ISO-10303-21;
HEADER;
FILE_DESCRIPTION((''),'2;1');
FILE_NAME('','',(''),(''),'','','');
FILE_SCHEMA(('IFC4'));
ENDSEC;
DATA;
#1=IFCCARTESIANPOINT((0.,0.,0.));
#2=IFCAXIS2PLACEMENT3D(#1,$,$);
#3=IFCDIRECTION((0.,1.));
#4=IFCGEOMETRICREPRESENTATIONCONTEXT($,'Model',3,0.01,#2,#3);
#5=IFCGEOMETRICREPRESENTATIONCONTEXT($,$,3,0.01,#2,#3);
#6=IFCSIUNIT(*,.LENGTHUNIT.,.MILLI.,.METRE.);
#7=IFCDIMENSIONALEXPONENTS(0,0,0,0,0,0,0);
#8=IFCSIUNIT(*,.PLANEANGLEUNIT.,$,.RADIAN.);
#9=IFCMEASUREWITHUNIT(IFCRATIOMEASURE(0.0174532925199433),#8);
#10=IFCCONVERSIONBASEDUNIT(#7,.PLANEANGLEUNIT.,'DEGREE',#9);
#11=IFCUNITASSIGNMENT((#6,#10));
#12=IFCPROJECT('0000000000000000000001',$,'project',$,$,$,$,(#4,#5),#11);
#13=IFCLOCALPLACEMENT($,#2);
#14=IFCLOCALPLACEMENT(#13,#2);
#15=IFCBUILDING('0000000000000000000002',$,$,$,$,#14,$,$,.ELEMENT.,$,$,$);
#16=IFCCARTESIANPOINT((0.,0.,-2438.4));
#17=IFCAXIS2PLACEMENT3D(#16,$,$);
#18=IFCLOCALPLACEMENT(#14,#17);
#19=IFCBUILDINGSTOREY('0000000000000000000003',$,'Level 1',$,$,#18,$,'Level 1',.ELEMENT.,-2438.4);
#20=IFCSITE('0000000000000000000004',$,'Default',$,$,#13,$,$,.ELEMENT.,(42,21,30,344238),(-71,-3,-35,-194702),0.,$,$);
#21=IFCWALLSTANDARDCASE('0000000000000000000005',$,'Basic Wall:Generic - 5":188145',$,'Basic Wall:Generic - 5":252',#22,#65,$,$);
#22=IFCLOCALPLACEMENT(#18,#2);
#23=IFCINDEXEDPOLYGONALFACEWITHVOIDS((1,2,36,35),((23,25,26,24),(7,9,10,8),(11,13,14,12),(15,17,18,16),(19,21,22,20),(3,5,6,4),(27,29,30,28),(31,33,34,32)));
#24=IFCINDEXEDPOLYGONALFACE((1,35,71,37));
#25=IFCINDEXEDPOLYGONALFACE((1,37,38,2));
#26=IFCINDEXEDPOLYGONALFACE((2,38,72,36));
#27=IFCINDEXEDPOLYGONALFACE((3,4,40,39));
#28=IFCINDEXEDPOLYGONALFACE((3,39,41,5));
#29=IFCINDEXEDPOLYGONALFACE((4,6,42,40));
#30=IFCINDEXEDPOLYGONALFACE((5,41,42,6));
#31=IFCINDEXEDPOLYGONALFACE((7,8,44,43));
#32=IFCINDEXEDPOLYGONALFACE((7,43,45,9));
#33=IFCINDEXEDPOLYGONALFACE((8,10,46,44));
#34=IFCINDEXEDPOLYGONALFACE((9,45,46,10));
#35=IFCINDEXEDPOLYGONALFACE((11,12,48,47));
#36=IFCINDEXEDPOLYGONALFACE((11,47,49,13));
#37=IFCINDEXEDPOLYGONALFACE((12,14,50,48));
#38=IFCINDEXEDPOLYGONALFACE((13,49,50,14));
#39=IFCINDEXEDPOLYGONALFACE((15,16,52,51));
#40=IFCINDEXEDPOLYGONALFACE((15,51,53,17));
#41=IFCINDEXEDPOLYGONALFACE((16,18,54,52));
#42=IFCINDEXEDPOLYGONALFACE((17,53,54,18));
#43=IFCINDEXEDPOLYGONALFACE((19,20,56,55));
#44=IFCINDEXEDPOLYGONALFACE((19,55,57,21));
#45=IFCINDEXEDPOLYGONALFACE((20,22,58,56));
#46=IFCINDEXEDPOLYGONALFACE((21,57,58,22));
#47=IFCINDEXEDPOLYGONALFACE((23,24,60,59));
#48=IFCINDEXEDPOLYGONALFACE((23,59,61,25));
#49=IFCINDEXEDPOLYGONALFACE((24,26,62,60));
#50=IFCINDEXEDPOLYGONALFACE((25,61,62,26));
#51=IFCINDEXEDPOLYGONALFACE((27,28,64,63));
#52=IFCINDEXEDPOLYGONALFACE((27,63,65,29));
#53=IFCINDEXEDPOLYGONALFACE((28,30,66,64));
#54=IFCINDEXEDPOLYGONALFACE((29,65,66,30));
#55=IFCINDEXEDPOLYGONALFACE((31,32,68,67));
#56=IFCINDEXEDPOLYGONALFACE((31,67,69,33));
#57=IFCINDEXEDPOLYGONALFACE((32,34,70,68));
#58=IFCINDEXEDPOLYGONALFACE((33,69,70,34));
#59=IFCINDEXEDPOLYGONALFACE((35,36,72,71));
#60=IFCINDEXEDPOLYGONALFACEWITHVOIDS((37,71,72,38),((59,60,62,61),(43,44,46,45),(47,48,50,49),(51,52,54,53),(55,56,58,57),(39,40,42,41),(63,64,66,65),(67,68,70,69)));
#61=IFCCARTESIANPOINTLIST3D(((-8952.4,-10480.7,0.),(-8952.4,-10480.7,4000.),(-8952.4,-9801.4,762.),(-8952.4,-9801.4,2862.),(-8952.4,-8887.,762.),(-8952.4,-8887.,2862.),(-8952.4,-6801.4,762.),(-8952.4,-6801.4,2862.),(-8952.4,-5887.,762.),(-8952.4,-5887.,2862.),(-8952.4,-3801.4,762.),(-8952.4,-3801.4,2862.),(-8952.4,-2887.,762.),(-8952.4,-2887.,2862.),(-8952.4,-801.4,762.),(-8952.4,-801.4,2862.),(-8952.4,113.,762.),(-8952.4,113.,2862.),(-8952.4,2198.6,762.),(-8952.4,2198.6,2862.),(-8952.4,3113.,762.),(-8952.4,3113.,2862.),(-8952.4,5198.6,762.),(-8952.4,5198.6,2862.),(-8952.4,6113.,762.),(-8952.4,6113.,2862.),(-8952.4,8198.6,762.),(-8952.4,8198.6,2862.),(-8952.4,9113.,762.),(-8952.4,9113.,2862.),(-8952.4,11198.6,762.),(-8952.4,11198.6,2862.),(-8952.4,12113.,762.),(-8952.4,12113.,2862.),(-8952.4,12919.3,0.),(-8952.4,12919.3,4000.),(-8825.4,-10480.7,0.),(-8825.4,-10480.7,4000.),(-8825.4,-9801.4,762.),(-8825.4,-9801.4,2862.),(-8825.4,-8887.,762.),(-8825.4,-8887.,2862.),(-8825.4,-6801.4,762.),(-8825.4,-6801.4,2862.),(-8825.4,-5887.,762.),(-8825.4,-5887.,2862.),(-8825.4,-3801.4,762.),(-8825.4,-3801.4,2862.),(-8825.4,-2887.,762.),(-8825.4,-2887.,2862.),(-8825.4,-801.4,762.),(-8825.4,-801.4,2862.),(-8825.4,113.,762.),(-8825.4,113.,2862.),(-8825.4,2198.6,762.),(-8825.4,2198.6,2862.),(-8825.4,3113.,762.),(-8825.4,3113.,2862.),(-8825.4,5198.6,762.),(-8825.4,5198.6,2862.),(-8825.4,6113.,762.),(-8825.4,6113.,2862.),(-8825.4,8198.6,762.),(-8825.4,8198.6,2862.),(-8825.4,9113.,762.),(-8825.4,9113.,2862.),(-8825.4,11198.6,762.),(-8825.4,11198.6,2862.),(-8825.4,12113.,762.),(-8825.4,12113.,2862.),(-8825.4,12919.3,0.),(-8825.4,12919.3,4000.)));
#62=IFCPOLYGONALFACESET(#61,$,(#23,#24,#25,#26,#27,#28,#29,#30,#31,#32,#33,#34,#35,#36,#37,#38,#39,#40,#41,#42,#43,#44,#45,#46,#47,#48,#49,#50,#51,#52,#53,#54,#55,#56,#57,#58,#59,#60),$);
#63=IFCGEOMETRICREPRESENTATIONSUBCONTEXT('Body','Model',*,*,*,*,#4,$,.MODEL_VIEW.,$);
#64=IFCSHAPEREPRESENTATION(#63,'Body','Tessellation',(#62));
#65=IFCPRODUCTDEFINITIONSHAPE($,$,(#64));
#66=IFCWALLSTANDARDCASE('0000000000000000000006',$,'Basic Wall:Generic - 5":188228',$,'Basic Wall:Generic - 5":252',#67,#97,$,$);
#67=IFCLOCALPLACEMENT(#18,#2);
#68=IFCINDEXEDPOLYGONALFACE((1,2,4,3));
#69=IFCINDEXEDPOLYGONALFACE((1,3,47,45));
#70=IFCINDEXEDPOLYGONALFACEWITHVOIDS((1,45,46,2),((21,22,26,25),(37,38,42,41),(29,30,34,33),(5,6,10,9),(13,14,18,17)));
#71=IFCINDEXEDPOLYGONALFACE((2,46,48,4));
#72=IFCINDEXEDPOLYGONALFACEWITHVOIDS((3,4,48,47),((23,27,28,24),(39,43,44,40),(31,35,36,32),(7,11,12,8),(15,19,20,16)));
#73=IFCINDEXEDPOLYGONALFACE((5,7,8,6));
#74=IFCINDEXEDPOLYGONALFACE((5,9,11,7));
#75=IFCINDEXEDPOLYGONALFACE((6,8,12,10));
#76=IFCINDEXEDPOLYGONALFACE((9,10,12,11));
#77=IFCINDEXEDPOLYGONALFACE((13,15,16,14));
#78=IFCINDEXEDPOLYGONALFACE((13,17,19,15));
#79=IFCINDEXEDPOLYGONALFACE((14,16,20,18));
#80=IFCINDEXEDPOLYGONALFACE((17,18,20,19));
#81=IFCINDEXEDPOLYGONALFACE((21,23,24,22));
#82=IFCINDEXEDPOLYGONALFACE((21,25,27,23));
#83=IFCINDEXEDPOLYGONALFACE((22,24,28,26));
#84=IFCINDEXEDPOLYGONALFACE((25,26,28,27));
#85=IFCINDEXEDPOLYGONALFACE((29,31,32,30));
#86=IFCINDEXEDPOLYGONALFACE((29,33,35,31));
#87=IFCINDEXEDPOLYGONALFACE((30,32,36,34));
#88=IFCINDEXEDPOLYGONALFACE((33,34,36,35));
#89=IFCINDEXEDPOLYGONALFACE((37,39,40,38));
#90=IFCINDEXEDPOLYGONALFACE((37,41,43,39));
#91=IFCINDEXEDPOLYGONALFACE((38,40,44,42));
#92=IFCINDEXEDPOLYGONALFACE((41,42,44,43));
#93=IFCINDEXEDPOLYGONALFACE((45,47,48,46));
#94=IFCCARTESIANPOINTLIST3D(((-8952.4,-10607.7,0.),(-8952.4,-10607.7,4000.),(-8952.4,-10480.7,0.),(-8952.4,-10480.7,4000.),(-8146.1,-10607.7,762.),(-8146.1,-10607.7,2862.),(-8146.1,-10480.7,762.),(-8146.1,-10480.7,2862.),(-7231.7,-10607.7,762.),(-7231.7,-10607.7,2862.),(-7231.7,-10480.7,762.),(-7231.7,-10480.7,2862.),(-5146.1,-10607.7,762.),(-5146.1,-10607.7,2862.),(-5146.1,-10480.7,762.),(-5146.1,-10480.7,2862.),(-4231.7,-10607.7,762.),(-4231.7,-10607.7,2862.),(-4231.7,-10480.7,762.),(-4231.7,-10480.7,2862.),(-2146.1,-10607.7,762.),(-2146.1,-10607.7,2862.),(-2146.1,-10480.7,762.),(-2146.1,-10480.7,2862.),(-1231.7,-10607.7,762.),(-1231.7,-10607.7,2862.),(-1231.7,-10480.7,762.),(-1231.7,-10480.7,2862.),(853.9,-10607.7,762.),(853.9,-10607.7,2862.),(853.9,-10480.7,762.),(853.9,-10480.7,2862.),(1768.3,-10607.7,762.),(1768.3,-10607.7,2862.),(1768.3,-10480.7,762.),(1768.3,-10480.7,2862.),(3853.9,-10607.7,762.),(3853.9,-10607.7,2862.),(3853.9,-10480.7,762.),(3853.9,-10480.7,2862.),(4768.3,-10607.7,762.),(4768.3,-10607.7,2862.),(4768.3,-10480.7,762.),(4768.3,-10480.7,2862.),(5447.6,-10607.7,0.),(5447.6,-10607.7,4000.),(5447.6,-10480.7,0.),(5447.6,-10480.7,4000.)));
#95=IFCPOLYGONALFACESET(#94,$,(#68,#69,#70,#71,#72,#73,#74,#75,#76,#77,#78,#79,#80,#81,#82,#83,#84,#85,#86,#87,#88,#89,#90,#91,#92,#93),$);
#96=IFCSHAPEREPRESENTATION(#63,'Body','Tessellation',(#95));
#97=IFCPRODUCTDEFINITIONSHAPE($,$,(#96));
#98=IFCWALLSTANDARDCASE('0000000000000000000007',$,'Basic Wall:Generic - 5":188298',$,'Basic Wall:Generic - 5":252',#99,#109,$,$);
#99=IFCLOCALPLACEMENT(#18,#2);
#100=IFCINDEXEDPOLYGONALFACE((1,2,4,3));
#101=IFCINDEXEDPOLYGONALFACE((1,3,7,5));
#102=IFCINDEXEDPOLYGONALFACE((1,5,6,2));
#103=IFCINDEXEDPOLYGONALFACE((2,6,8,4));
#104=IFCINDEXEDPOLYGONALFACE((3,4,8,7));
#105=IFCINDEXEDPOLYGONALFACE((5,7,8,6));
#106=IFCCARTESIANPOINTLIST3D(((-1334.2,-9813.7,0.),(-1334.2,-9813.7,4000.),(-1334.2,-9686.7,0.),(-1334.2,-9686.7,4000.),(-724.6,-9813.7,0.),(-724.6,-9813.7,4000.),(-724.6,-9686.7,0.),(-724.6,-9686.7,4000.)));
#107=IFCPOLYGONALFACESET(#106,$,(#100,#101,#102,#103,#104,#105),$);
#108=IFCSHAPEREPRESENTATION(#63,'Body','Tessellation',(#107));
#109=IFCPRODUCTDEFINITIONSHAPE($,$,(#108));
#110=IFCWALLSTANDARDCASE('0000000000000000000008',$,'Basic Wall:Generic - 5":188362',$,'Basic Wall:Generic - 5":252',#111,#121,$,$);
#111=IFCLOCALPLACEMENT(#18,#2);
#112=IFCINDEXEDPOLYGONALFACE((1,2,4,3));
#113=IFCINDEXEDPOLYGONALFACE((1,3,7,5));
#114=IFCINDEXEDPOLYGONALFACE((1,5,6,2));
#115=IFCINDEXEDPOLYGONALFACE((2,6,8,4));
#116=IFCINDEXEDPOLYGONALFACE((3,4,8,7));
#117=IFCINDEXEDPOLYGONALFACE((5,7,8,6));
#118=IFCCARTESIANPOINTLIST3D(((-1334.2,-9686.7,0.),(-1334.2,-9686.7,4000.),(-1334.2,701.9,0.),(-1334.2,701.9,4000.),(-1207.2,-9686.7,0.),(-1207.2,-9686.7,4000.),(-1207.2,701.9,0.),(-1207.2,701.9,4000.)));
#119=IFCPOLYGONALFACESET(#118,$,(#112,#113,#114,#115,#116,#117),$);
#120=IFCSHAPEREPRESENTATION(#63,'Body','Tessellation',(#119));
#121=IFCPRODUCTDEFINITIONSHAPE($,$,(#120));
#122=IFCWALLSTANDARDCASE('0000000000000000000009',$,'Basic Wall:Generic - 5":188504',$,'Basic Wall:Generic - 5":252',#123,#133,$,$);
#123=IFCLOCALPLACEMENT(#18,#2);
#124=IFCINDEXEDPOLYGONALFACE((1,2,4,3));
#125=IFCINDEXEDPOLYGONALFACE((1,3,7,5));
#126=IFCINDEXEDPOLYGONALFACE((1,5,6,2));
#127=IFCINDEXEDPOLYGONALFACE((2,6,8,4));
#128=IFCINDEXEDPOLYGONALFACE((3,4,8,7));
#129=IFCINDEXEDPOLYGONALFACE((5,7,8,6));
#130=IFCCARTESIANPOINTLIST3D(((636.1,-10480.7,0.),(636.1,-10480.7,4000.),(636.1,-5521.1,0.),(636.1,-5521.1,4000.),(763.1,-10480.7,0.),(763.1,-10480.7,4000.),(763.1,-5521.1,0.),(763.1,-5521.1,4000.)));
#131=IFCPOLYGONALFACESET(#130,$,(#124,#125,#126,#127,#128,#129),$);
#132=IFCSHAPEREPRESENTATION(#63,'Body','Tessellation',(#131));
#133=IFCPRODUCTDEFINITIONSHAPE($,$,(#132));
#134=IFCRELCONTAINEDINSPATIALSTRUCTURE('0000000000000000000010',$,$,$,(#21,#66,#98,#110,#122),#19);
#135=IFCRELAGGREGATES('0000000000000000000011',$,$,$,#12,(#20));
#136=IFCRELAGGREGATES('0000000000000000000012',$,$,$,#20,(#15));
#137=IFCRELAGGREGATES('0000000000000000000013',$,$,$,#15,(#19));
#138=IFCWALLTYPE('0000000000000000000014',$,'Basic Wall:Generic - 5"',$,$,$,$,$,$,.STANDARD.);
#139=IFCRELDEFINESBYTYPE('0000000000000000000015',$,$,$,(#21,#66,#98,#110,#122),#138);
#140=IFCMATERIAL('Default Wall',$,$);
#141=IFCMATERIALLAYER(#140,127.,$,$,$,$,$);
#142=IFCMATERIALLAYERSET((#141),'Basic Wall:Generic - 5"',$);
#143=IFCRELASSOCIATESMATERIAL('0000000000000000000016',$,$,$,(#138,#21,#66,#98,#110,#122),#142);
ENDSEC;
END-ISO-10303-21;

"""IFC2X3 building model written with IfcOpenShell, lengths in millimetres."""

from ifc_helpers import new_model, entity, si_unit, converted_unit, direction, frame, frame_2d, origin, place, context, subcontext, project, spatial, polyline, rectangle, extrude, clip, bounded_halfspace, material, layer, layer_set, layer_usage, type_object, element, save


model = new_model("IFC2X3")

# Units and contexts
model_context = context("Model", 3, precision=0.01, world=origin(), true_north=direction((0.0, 1.0)))
context_of_model = context(None, 3, precision=0.01, world=origin(), true_north=direction((0.0, 1.0)))
body_context = subcontext(model_context, "Body", "Model", "MODEL_VIEW")
ifc_project = project(units=[si_unit("LENGTHUNIT", "METRE", prefix="MILLI"), converted_unit("PLANEANGLEUNIT", "DEGREE", entity("IfcRatioMeasure", 0.0174532925199433), si_unit("PLANEANGLEUNIT", "RADIAN"), dimensions=[0, 0, 0, 0, 0, 0, 0])], contexts=[model_context, context_of_model])

# Site, building, storey
site_placement = place(None, origin())
site = spatial("IfcSite", under=ifc_project, at=site_placement, Name="Default", CompositionType="ELEMENT", RefLatitude=(42, 21, 30, 344238), RefLongitude=(-71, -3, -35, -194702), RefElevation=0.0)
building_placement = place(site_placement, origin())
building = spatial("IfcBuilding", under=site, at=building_placement, CompositionType="ELEMENT")
storey_placement = place(building_placement, frame((0.0, 0.0, -2438.4)))
storey = spatial("IfcBuildingStorey", under=building, at=storey_placement, Name="Level 1", LongName="Level 1", CompositionType="ELEMENT", Elevation=-2438.4)

# Walls, openings
ifc_material = material(Name="Default Wall")
ifc_layer = layer(ifc_material, 127.0)
ifc_layer_set = layer_set([ifc_layer], Name="Basic Wall:Generic - 5\"")
ifc_layer_usage_1 = layer_usage(ifc_layer_set, "AXIS2", "NEGATIVE", 63.5)
wall_type = type_object("IfcWallType", Name="Basic Wall:Generic - 5\"", PredefinedType="STANDARD", material=ifc_layer_set)
wall_1_placement = place(storey_placement, frame((-8888.9, -10480.7, 0.0), z_axis=(0.0, 0.0, 1.0), x_axis=(0.0, 1.0, 0.0)))
wall_1 = element("IfcWallStandardCase", 1, at=wall_1_placement, inside=storey, type_object=wall_type, material=ifc_layer_usage_1, Name="Basic Wall:Generic - 5\":188145", ObjectType="Basic Wall:Generic - 5\":252", context=body_context, shape_type="Clipping", body=[
    clip(extrude(rectangle(XDim=23400.0, YDim=127.0, at=frame_2d((11700.0, 0.0), x_axis=(-1.0, 0.0))), origin(), (0.0, 0.0, 1.0), 4000.0), bounded_halfspace(frame((0.0, -63.5, 4000.0), z_axis=(0.0, 0.0, -1.0), x_axis=(-1.0, 0.0, 0.0)), True, frame((0.0, -63.5, 4000.0)), polyline([(0.0, 0.0), (10928.6, 0.0), (11055.6, 0.0), (23273.0, 0.0), (23400.0, 0.0), (23400.0, 127.0), (0.0, 127.0), (0.0, 0.0)]))),
])
opening_1_placement = place(wall_1_placement, frame((21679.3, -63.5, 762.0)))
element("IfcOpeningElement", 2, at=opening_1_placement, cuts=wall_1, ObjectType="Opening", context=body_context, shape_type="SweptSolid", body=[
    extrude(rectangle(XDim=2100.0, YDim=914.4, at=frame_2d((1050.0, 457.2), x_axis=(-1.0, 0.0))), frame((0.0, 0.0, 0.0), z_axis=(0.0, 1.0, 0.0), x_axis=(0.0, 0.0, 1.0)), (0.0, 0.0, 1.0), 127.0),
])
opening_2_placement = place(wall_1_placement, frame((18679.3, -63.5, 762.0)))
element("IfcOpeningElement", 3, at=opening_2_placement, cuts=wall_1, ObjectType="Opening", context=body_context, shape_type="SweptSolid", body=[
    extrude(rectangle(XDim=2100.0, YDim=914.4, at=frame_2d((1050.0, 457.2), x_axis=(-1.0, 0.0))), frame((0.0, 0.0, 0.0), z_axis=(0.0, 1.0, 0.0), x_axis=(0.0, 0.0, 1.0)), (0.0, 0.0, 1.0), 127.0),
])
opening_3_placement = place(wall_1_placement, frame((15679.3, -63.5, 762.0)))
element("IfcOpeningElement", 4, at=opening_3_placement, cuts=wall_1, ObjectType="Opening", context=body_context, shape_type="SweptSolid", body=[
    extrude(rectangle(XDim=2100.0, YDim=914.4, at=frame_2d((1050.0, 457.2), x_axis=(-1.0, 0.0))), frame((0.0, 0.0, 0.0), z_axis=(0.0, 1.0, 0.0), x_axis=(0.0, 0.0, 1.0)), (0.0, 0.0, 1.0), 127.0),
])
opening_4_placement = place(wall_1_placement, frame((12679.3, -63.5, 762.0)))
element("IfcOpeningElement", 5, at=opening_4_placement, cuts=wall_1, ObjectType="Opening", context=body_context, shape_type="SweptSolid", body=[
    extrude(rectangle(XDim=2100.0, YDim=914.4, at=frame_2d((1050.0, 457.2), x_axis=(-1.0, 0.0))), frame((0.0, 0.0, 0.0), z_axis=(0.0, 1.0, 0.0), x_axis=(0.0, 0.0, 1.0)), (0.0, 0.0, 1.0), 127.0),
])
opening_5_placement = place(wall_1_placement, frame((9679.3, -63.5, 762.0)))
element("IfcOpeningElement", 6, at=opening_5_placement, cuts=wall_1, ObjectType="Opening", context=body_context, shape_type="SweptSolid", body=[
    extrude(rectangle(XDim=2100.0, YDim=914.4, at=frame_2d((1050.0, 457.2), x_axis=(-1.0, 0.0))), frame((0.0, 0.0, 0.0), z_axis=(0.0, 1.0, 0.0), x_axis=(0.0, 0.0, 1.0)), (0.0, 0.0, 1.0), 127.0),
])
opening_6_placement = place(wall_1_placement, frame((6679.3, -63.5, 762.0)))
element("IfcOpeningElement", 7, at=opening_6_placement, cuts=wall_1, ObjectType="Opening", context=body_context, shape_type="SweptSolid", body=[
    extrude(rectangle(XDim=2100.0, YDim=914.4, at=frame_2d((1050.0, 457.2), x_axis=(-1.0, 0.0))), frame((0.0, 0.0, 0.0), z_axis=(0.0, 1.0, 0.0), x_axis=(0.0, 0.0, 1.0)), (0.0, 0.0, 1.0), 127.0),
])
opening_7_placement = place(wall_1_placement, frame((3679.3, -63.5, 762.0)))
element("IfcOpeningElement", 8, at=opening_7_placement, cuts=wall_1, ObjectType="Opening", context=body_context, shape_type="SweptSolid", body=[
    extrude(rectangle(XDim=2100.0, YDim=914.4, at=frame_2d((1050.0, 457.2), x_axis=(-1.0, 0.0))), frame((0.0, 0.0, 0.0), z_axis=(0.0, 1.0, 0.0), x_axis=(0.0, 0.0, 1.0)), (0.0, 0.0, 1.0), 127.0),
])
opening_8_placement = place(wall_1_placement, frame((679.3, -63.5, 762.0)))
element("IfcOpeningElement", 9, at=opening_8_placement, cuts=wall_1, ObjectType="Opening", context=body_context, shape_type="SweptSolid", body=[
    extrude(rectangle(XDim=2100.0, YDim=914.4, at=frame_2d((1050.0, 457.2), x_axis=(-1.0, 0.0))), frame((0.0, 0.0, 0.0), z_axis=(0.0, 1.0, 0.0), x_axis=(0.0, 0.0, 1.0)), (0.0, 0.0, 1.0), 127.0),
])
ifc_layer_usage_2 = layer_usage(ifc_layer_set, "AXIS2", "NEGATIVE", 63.5)
wall_2_placement = place(storey_placement, frame((5447.6, -10544.2, 0.0), z_axis=(0.0, 0.0, 1.0), x_axis=(-1.0, 0.0, 0.0)))
wall_2 = element("IfcWallStandardCase", 10, at=wall_2_placement, inside=storey, type_object=wall_type, material=ifc_layer_usage_2, Name="Basic Wall:Generic - 5\":188228", ObjectType="Basic Wall:Generic - 5\":252", context=body_context, shape_type="Clipping", body=[
    clip(extrude(rectangle(XDim=14400.0, YDim=127.0, at=frame_2d((7200.0, 0.0), x_axis=(-1.0, 0.0))), origin(), (0.0, 0.0, 1.0), 4000.0), bounded_halfspace(frame((0.0, -63.5, 4000.0), z_axis=(0.0, 0.0, -1.0), x_axis=(0.0, 1.0, 0.0)), True, frame((0.0, -63.5, 4000.0)), polyline([(0.0, 0.0), (4684.5, 0.0), (4811.5, 0.0), (14273.0, 0.0), (14400.0, 0.0), (14400.0, 127.0), (0.0, 127.0), (0.0, 0.0)]))),
])
opening_9_placement = place(wall_2_placement, frame((1593.7, 63.5, 762.0)))
element("IfcOpeningElement", 11, at=opening_9_placement, cuts=wall_2, ObjectType="Opening", context=body_context, shape_type="SweptSolid", body=[
    extrude(rectangle(XDim=2100.0, YDim=914.4, at=frame_2d((1050.0, 457.2), x_axis=(-1.0, 0.0))), frame((0.0, 0.0, 0.0), z_axis=(0.0, -1.0, 0.0), x_axis=(0.0, 0.0, 1.0)), (0.0, 0.0, 1.0), 127.0),
])
opening_10_placement = place(wall_2_placement, frame((3679.3, -63.5, 762.0)))
element("IfcOpeningElement", 12, at=opening_10_placement, cuts=wall_2, ObjectType="Opening", context=body_context, shape_type="SweptSolid", body=[
    extrude(rectangle(XDim=2100.0, YDim=914.4, at=frame_2d((1050.0, 457.2), x_axis=(-1.0, 0.0))), frame((0.0, 0.0, 0.0), z_axis=(0.0, 1.0, 0.0), x_axis=(0.0, 0.0, 1.0)), (0.0, 0.0, 1.0), 127.0),
])
opening_11_placement = place(wall_2_placement, frame((6679.3, -63.5, 762.0)))
element("IfcOpeningElement", 13, at=opening_11_placement, cuts=wall_2, ObjectType="Opening", context=body_context, shape_type="SweptSolid", body=[
    extrude(rectangle(XDim=2100.0, YDim=914.4, at=frame_2d((1050.0, 457.2), x_axis=(-1.0, 0.0))), frame((0.0, 0.0, 0.0), z_axis=(0.0, 1.0, 0.0), x_axis=(0.0, 0.0, 1.0)), (0.0, 0.0, 1.0), 127.0),
])
opening_12_placement = place(wall_2_placement, frame((10593.7, 63.5, 762.0)))
element("IfcOpeningElement", 14, at=opening_12_placement, cuts=wall_2, ObjectType="Opening", context=body_context, shape_type="SweptSolid", body=[
    extrude(rectangle(XDim=2100.0, YDim=914.4, at=frame_2d((1050.0, 457.2), x_axis=(-1.0, 0.0))), frame((0.0, 0.0, 0.0), z_axis=(0.0, -1.0, 0.0), x_axis=(0.0, 0.0, 1.0)), (0.0, 0.0, 1.0), 127.0),
])
opening_13_placement = place(wall_2_placement, frame((13593.7, 63.5, 762.0)))
element("IfcOpeningElement", 15, at=opening_13_placement, cuts=wall_2, ObjectType="Opening", context=body_context, shape_type="SweptSolid", body=[
    extrude(rectangle(XDim=2100.0, YDim=914.4, at=frame_2d((1050.0, 457.2), x_axis=(-1.0, 0.0))), frame((0.0, 0.0, 0.0), z_axis=(0.0, -1.0, 0.0), x_axis=(0.0, 0.0, 1.0)), (0.0, 0.0, 1.0), 127.0),
])

# Walls
ifc_layer_usage_3 = layer_usage(ifc_layer_set, "AXIS2", "POSITIVE", -63.5)
wall_3_placement = place(storey_placement, frame((-1334.2, -9750.2, 0.0)))
element("IfcWallStandardCase", 16, at=wall_3_placement, inside=storey, type_object=wall_type, material=ifc_layer_usage_3, Name="Basic Wall:Generic - 5\":188298", ObjectType="Basic Wall:Generic - 5\":252", context=body_context, shape_type="Clipping", body=[
    clip(extrude(rectangle(XDim=609.6, YDim=127.0, at=frame_2d((304.8, 0.0), x_axis=(-1.0, 0.0))), origin(), (0.0, 0.0, 1.0), 4000.0), bounded_halfspace(frame((0.0, -63.5, 4000.0), z_axis=(0.0, 0.0, -1.0), x_axis=(0.0, -1.0, 0.0)), True, frame((0.0, -63.5, 4000.0)), polyline([(0.0, 0.0), (609.6, 0.0), (609.6, 127.0), (127.0, 127.0), (0.0, 127.0), (0.0, 0.0)]))),
])
ifc_layer_usage_4 = layer_usage(ifc_layer_set, "AXIS2", "NEGATIVE", 63.5)
wall_4_placement = place(storey_placement, frame((-1270.7, -9686.7, 0.0), z_axis=(0.0, 0.0, 1.0), x_axis=(0.0, 1.0, 0.0)))
element("IfcWallStandardCase", 17, at=wall_4_placement, inside=storey, type_object=wall_type, material=ifc_layer_usage_4, Name="Basic Wall:Generic - 5\":188362", ObjectType="Basic Wall:Generic - 5\":252", context=body_context, shape_type="Clipping", body=[
    clip(extrude(rectangle(XDim=10388.6, YDim=127.0, at=frame_2d((5194.3, 0.0), x_axis=(-1.0, 0.0))), origin(), (0.0, 0.0, 1.0), 4000.0), bounded_halfspace(frame((0.0, -63.5, 4000.0), z_axis=(0.0, 0.0, -1.0), x_axis=(-1.0, 0.0, 0.0)), True, frame((0.0, -63.5, 4000.0)), polyline([(0.0, 0.0), (10261.6, 0.0), (10388.6, 0.0), (10388.6, 127.0), (0.0, 127.0), (0.0, 0.0)]))),
])
ifc_layer_usage_5 = layer_usage(ifc_layer_set, "AXIS2", "NEGATIVE", 63.5)
wall_5_placement = place(storey_placement, frame((699.6, -10480.7, 0.0), z_axis=(0.0, 0.0, 1.0), x_axis=(0.0, 1.0, 0.0)))
element("IfcWallStandardCase", 18, at=wall_5_placement, inside=storey, type_object=wall_type, material=ifc_layer_usage_5, Name="Basic Wall:Generic - 5\":188504", ObjectType="Basic Wall:Generic - 5\":252", context=body_context, shape_type="Clipping", body=[
    clip(extrude(rectangle(XDim=4959.6, YDim=127.0, at=frame_2d((2479.8, 0.0), x_axis=(-1.0, 0.0))), origin(), (0.0, 0.0, 1.0), 4000.0), bounded_halfspace(frame((0.0, -63.5, 4000.0), z_axis=(0.0, 0.0, -1.0), x_axis=(-1.0, 0.0, 0.0)), True, frame((0.0, -63.5, 4000.0)), polyline([(0.0, 0.0), (2368.8, 0.0), (2495.8, 0.0), (4959.6, 0.0), (4959.6, 127.0), (0.0, 127.0), (0.0, 0.0)]))),
])

save(model, "model.ifc")
